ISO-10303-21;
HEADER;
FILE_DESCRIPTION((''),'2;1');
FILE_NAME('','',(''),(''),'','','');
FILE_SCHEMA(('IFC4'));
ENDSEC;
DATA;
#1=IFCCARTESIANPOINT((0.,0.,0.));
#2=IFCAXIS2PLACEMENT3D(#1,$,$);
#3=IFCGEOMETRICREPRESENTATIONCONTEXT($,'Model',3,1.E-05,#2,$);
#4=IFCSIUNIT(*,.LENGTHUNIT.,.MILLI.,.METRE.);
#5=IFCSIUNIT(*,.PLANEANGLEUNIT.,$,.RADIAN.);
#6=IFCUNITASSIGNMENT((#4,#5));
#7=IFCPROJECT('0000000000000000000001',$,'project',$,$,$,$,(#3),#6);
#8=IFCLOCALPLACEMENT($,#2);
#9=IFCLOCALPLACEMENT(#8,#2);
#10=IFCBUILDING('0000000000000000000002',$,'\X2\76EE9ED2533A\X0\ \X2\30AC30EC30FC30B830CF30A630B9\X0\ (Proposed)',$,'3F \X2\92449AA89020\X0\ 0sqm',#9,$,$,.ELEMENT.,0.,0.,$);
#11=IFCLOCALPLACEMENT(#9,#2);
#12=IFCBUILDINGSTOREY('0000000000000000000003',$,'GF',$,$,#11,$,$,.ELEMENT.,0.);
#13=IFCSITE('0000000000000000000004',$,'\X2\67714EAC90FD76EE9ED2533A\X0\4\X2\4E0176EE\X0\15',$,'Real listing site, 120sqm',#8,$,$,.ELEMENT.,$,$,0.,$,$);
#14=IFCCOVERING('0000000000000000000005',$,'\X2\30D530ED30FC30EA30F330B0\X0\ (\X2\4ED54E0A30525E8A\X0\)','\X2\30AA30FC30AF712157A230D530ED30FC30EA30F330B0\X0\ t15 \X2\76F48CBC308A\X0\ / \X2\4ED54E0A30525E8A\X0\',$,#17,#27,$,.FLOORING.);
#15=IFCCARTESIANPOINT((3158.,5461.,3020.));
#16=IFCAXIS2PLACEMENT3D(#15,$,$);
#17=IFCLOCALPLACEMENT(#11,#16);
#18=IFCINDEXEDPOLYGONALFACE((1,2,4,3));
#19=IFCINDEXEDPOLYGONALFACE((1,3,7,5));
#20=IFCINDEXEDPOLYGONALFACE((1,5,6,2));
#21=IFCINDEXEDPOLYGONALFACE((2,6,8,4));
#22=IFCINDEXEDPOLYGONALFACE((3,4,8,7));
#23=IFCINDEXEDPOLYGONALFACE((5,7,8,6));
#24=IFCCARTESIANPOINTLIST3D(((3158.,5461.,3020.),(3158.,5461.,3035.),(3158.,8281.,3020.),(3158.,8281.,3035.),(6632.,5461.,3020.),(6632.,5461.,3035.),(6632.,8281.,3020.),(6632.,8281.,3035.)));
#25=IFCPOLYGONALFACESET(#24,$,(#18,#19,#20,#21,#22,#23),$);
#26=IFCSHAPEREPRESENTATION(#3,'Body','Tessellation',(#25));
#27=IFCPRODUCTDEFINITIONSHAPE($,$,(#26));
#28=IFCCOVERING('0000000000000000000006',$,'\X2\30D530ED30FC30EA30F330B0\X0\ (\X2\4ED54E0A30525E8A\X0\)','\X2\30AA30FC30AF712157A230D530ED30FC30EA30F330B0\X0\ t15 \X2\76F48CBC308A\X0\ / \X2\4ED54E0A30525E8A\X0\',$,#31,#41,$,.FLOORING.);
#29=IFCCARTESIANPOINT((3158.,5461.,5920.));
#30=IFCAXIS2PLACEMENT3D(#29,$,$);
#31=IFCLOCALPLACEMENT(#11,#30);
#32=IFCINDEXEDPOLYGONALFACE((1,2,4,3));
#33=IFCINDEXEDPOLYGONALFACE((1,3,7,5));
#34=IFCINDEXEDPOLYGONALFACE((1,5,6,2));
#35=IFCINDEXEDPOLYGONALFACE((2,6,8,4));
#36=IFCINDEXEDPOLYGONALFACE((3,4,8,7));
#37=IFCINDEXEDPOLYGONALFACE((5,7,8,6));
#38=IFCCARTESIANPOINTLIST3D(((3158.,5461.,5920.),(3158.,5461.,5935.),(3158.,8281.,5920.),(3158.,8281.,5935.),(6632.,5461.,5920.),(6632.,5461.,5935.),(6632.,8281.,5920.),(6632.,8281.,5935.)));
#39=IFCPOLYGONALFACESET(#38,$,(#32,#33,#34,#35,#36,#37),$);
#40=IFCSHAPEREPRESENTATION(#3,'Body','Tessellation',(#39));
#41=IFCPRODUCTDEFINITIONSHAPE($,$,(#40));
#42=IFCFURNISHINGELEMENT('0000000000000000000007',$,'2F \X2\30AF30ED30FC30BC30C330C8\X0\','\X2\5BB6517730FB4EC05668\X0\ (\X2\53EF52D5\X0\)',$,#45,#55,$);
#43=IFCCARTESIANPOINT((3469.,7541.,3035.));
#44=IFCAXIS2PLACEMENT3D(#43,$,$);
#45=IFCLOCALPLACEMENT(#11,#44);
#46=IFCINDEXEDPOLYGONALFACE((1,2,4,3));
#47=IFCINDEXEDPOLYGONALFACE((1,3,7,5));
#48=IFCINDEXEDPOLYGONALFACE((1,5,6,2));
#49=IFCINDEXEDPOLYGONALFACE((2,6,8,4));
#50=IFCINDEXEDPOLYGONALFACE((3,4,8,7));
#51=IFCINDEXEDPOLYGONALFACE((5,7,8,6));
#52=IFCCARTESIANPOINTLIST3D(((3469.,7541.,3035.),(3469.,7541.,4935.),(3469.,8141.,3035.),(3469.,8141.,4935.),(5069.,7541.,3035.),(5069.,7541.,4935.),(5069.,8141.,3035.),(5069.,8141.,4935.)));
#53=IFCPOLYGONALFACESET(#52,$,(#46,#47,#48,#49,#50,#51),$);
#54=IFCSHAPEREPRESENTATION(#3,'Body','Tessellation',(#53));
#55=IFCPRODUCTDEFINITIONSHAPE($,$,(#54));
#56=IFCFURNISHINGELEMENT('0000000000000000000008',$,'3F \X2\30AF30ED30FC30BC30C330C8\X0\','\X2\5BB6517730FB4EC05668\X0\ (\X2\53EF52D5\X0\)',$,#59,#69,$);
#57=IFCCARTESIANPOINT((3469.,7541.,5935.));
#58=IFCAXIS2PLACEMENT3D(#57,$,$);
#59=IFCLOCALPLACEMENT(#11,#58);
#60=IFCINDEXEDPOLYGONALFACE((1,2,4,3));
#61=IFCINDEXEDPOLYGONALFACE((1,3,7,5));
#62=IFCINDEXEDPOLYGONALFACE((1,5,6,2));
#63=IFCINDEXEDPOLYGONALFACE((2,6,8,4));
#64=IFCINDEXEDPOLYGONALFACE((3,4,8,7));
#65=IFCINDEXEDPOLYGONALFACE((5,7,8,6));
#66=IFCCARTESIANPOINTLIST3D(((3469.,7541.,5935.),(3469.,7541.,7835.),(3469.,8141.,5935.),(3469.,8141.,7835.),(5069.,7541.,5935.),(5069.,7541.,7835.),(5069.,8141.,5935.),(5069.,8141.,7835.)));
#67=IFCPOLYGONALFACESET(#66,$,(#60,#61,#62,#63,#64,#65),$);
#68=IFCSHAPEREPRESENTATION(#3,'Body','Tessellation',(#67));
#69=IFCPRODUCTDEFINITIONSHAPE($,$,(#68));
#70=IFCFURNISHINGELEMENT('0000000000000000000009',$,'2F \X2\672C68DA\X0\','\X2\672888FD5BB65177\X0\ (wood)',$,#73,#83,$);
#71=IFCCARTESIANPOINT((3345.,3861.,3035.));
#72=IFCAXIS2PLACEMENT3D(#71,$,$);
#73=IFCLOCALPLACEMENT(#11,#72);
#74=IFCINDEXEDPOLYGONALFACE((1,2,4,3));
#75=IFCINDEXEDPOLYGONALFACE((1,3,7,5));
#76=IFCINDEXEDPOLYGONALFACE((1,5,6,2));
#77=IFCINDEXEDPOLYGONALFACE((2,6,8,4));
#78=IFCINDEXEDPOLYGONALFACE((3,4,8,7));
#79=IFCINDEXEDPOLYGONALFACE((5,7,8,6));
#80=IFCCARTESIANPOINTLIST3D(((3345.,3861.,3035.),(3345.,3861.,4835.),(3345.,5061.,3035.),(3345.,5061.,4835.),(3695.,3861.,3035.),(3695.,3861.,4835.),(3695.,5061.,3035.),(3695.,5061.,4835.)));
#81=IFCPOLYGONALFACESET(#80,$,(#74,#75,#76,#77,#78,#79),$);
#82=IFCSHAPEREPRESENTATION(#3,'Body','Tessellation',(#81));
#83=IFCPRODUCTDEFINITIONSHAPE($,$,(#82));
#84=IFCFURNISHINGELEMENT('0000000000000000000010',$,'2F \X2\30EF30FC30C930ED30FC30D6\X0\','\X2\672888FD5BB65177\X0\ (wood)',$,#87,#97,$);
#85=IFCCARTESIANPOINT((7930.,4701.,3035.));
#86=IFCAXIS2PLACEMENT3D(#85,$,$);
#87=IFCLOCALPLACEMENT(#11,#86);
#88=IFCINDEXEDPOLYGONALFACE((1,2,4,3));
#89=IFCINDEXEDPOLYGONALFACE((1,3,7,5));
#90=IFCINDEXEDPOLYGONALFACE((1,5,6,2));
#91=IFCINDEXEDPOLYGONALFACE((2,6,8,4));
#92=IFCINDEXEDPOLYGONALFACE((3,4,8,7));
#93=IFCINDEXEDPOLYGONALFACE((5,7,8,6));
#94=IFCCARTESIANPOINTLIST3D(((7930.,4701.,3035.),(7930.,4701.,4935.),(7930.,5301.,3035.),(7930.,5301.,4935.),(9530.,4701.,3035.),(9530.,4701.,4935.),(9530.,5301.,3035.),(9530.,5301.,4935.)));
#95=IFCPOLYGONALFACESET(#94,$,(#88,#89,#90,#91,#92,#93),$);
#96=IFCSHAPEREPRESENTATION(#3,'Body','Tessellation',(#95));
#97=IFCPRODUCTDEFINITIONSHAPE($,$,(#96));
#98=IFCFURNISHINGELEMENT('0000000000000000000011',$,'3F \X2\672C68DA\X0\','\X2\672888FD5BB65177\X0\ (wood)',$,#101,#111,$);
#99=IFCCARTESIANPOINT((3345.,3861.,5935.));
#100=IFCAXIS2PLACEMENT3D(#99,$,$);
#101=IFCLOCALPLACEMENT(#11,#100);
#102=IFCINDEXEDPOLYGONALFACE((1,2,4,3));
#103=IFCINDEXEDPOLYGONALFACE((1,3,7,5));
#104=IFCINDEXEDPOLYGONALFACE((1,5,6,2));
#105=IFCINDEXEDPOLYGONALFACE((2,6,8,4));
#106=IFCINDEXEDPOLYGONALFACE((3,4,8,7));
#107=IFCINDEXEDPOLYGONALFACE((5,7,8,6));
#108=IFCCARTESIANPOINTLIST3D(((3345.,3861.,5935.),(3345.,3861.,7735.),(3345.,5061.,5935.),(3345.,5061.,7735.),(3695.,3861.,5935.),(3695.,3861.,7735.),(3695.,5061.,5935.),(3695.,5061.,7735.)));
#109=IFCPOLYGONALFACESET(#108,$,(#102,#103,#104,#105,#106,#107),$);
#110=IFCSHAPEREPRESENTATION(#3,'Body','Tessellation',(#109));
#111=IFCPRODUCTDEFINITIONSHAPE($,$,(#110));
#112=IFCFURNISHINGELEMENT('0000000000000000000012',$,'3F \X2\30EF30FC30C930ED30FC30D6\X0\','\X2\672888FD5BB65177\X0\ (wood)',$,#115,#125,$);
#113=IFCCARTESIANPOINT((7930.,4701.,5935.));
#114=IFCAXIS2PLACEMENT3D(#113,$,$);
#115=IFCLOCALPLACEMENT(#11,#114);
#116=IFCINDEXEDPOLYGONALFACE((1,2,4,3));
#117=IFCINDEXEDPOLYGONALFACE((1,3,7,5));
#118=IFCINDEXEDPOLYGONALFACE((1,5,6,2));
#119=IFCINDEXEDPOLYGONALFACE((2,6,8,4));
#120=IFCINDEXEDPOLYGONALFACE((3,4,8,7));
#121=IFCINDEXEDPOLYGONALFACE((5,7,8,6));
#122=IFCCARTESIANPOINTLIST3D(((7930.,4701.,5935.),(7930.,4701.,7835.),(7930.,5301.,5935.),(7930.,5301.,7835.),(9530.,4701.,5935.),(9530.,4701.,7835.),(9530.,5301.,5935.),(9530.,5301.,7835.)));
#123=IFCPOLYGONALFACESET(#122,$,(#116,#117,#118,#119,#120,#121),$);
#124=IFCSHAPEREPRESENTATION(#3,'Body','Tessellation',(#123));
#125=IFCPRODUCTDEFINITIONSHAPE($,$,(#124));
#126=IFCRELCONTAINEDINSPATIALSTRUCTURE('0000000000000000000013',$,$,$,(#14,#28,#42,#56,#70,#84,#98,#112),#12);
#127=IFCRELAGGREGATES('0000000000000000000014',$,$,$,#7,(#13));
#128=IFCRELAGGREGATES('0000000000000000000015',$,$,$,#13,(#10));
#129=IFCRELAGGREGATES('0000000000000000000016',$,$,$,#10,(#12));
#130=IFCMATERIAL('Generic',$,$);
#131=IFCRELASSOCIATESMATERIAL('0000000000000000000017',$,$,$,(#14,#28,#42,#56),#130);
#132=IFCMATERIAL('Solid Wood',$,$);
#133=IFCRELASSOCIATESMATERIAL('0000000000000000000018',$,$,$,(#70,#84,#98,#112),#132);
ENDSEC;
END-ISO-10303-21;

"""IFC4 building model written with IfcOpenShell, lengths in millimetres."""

from ifc_helpers import new_model, si_unit, frame, frame_2d, origin, place, context, project, spatial, rectangle, extrude, material, element, save


model = new_model("IFC4")

# Units and contexts
model_context = context("Model", 3, precision=1e-05, world=origin())
ifc_project = project(units=[si_unit("LENGTHUNIT", "METRE", prefix="MILLI"), si_unit("PLANEANGLEUNIT", "RADIAN")], contexts=[model_context])

# Site, building, storey
site_placement = place(None, origin())
site = spatial("IfcSite", under=ifc_project, at=site_placement, Name="東京都目黒区4丁目15", ObjectType="Real listing site, 120sqm", CompositionType="ELEMENT", RefElevation=0.0)
building_placement = place(site_placement, origin())
building = spatial("IfcBuilding", under=site, at=building_placement, Name="目黒区 ガレージハウス (Proposed)", ObjectType="3F 鉄骨造 0sqm", CompositionType="ELEMENT", ElevationOfRefHeight=0.0, ElevationOfTerrain=0.0)
storey_placement = place(building_placement, origin())
storey = spatial("IfcBuildingStorey", under=building, at=storey_placement, Name="GF", CompositionType="ELEMENT", Elevation=0.0)

# Shared definitions
ifc_material_1 = material(Name="Solid Wood")

# Coverings
ifc_material_2 = material(Name="Generic")
covering_1_placement = place(storey_placement, frame((3158.0, 5461.0, 3020.0)))
element("IfcCovering", 1, at=covering_1_placement, inside=storey, material=ifc_material_2, Name="フローリング (仕上げ床)", Description="オーク無垢フローリング t15 直貼り / 仕上げ床", PredefinedType="FLOORING", context=model_context, shape_type="SweptSolid", body=[
    extrude(rectangle(XDim=3474.0, YDim=2820.0, at=frame_2d((1737.0, 1410.0))), frame((3158.0, 5461.0, 3020.0)), (0.0, 0.0, 1.0), 15.0),
])
covering_2_placement = place(storey_placement, frame((3158.0, 5461.0, 5920.0)))
element("IfcCovering", 2, at=covering_2_placement, inside=storey, material=ifc_material_2, Name="フローリング (仕上げ床)", Description="オーク無垢フローリング t15 直貼り / 仕上げ床", PredefinedType="FLOORING", context=model_context, shape_type="SweptSolid", body=[
    extrude(rectangle(XDim=3474.0, YDim=2820.0, at=frame_2d((1737.0, 1410.0))), frame((3158.0, 5461.0, 5920.0)), (0.0, 0.0, 1.0), 15.0),
])

# Furnishing elements
furnishing_1_placement = place(storey_placement, frame((3469.0, 7541.0, 3035.0)))
element("IfcFurnishingElement", 3, at=furnishing_1_placement, inside=storey, material=ifc_material_2, Name="2F クローゼット", Description="家具・什器 (可動)", context=model_context, shape_type="SweptSolid", body=[
    extrude(rectangle(XDim=1600.0, YDim=600.0, at=frame_2d((800.0, 300.0))), frame((3469.0, 7541.0, 3035.0)), (0.0, 0.0, 1.0), 1900.0),
])
furnishing_2_placement = place(storey_placement, frame((3469.0, 7541.0, 5935.0)))
element("IfcFurnishingElement", 4, at=furnishing_2_placement, inside=storey, material=ifc_material_2, Name="3F クローゼット", Description="家具・什器 (可動)", context=model_context, shape_type="SweptSolid", body=[
    extrude(rectangle(XDim=1600.0, YDim=600.0, at=frame_2d((800.0, 300.0))), frame((3469.0, 7541.0, 5935.0)), (0.0, 0.0, 1.0), 1900.0),
])
furnishing_3_placement = place(storey_placement, frame((3345.0, 3861.0, 3035.0)))
element("IfcFurnishingElement", 5, at=furnishing_3_placement, inside=storey, material=ifc_material_1, Name="2F 本棚", Description="木製家具 (wood)", context=model_context, shape_type="SweptSolid", body=[
    extrude(rectangle(XDim=350.0, YDim=1200.0, at=frame_2d((175.0, 600.0))), frame((3345.0, 3861.0, 3035.0)), (0.0, 0.0, 1.0), 1800.0),
])
furnishing_4_placement = place(storey_placement, frame((7930.0, 4701.0, 3035.0)))
element("IfcFurnishingElement", 6, at=furnishing_4_placement, inside=storey, material=ifc_material_1, Name="2F ワードローブ", Description="木製家具 (wood)", context=model_context, shape_type="SweptSolid", body=[
    extrude(rectangle(XDim=1600.0, YDim=600.0, at=frame_2d((800.0, 300.0))), frame((7930.0, 4701.0, 3035.0)), (0.0, 0.0, 1.0), 1900.0),
])
furnishing_5_placement = place(storey_placement, frame((3345.0, 3861.0, 5935.0)))
element("IfcFurnishingElement", 7, at=furnishing_5_placement, inside=storey, material=ifc_material_1, Name="3F 本棚", Description="木製家具 (wood)", context=model_context, shape_type="SweptSolid", body=[
    extrude(rectangle(XDim=350.0, YDim=1200.0, at=frame_2d((175.0, 600.0))), frame((3345.0, 3861.0, 5935.0)), (0.0, 0.0, 1.0), 1800.0),
])
furnishing_6_placement = place(storey_placement, frame((7930.0, 4701.0, 5935.0)))
element("IfcFurnishingElement", 8, at=furnishing_6_placement, inside=storey, material=ifc_material_1, Name="3F ワードローブ", Description="木製家具 (wood)", context=model_context, shape_type="SweptSolid", body=[
    extrude(rectangle(XDim=1600.0, YDim=600.0, at=frame_2d((800.0, 300.0))), frame((7930.0, 4701.0, 5935.0)), (0.0, 0.0, 1.0), 1900.0),
])

save(model, "model.ifc")
